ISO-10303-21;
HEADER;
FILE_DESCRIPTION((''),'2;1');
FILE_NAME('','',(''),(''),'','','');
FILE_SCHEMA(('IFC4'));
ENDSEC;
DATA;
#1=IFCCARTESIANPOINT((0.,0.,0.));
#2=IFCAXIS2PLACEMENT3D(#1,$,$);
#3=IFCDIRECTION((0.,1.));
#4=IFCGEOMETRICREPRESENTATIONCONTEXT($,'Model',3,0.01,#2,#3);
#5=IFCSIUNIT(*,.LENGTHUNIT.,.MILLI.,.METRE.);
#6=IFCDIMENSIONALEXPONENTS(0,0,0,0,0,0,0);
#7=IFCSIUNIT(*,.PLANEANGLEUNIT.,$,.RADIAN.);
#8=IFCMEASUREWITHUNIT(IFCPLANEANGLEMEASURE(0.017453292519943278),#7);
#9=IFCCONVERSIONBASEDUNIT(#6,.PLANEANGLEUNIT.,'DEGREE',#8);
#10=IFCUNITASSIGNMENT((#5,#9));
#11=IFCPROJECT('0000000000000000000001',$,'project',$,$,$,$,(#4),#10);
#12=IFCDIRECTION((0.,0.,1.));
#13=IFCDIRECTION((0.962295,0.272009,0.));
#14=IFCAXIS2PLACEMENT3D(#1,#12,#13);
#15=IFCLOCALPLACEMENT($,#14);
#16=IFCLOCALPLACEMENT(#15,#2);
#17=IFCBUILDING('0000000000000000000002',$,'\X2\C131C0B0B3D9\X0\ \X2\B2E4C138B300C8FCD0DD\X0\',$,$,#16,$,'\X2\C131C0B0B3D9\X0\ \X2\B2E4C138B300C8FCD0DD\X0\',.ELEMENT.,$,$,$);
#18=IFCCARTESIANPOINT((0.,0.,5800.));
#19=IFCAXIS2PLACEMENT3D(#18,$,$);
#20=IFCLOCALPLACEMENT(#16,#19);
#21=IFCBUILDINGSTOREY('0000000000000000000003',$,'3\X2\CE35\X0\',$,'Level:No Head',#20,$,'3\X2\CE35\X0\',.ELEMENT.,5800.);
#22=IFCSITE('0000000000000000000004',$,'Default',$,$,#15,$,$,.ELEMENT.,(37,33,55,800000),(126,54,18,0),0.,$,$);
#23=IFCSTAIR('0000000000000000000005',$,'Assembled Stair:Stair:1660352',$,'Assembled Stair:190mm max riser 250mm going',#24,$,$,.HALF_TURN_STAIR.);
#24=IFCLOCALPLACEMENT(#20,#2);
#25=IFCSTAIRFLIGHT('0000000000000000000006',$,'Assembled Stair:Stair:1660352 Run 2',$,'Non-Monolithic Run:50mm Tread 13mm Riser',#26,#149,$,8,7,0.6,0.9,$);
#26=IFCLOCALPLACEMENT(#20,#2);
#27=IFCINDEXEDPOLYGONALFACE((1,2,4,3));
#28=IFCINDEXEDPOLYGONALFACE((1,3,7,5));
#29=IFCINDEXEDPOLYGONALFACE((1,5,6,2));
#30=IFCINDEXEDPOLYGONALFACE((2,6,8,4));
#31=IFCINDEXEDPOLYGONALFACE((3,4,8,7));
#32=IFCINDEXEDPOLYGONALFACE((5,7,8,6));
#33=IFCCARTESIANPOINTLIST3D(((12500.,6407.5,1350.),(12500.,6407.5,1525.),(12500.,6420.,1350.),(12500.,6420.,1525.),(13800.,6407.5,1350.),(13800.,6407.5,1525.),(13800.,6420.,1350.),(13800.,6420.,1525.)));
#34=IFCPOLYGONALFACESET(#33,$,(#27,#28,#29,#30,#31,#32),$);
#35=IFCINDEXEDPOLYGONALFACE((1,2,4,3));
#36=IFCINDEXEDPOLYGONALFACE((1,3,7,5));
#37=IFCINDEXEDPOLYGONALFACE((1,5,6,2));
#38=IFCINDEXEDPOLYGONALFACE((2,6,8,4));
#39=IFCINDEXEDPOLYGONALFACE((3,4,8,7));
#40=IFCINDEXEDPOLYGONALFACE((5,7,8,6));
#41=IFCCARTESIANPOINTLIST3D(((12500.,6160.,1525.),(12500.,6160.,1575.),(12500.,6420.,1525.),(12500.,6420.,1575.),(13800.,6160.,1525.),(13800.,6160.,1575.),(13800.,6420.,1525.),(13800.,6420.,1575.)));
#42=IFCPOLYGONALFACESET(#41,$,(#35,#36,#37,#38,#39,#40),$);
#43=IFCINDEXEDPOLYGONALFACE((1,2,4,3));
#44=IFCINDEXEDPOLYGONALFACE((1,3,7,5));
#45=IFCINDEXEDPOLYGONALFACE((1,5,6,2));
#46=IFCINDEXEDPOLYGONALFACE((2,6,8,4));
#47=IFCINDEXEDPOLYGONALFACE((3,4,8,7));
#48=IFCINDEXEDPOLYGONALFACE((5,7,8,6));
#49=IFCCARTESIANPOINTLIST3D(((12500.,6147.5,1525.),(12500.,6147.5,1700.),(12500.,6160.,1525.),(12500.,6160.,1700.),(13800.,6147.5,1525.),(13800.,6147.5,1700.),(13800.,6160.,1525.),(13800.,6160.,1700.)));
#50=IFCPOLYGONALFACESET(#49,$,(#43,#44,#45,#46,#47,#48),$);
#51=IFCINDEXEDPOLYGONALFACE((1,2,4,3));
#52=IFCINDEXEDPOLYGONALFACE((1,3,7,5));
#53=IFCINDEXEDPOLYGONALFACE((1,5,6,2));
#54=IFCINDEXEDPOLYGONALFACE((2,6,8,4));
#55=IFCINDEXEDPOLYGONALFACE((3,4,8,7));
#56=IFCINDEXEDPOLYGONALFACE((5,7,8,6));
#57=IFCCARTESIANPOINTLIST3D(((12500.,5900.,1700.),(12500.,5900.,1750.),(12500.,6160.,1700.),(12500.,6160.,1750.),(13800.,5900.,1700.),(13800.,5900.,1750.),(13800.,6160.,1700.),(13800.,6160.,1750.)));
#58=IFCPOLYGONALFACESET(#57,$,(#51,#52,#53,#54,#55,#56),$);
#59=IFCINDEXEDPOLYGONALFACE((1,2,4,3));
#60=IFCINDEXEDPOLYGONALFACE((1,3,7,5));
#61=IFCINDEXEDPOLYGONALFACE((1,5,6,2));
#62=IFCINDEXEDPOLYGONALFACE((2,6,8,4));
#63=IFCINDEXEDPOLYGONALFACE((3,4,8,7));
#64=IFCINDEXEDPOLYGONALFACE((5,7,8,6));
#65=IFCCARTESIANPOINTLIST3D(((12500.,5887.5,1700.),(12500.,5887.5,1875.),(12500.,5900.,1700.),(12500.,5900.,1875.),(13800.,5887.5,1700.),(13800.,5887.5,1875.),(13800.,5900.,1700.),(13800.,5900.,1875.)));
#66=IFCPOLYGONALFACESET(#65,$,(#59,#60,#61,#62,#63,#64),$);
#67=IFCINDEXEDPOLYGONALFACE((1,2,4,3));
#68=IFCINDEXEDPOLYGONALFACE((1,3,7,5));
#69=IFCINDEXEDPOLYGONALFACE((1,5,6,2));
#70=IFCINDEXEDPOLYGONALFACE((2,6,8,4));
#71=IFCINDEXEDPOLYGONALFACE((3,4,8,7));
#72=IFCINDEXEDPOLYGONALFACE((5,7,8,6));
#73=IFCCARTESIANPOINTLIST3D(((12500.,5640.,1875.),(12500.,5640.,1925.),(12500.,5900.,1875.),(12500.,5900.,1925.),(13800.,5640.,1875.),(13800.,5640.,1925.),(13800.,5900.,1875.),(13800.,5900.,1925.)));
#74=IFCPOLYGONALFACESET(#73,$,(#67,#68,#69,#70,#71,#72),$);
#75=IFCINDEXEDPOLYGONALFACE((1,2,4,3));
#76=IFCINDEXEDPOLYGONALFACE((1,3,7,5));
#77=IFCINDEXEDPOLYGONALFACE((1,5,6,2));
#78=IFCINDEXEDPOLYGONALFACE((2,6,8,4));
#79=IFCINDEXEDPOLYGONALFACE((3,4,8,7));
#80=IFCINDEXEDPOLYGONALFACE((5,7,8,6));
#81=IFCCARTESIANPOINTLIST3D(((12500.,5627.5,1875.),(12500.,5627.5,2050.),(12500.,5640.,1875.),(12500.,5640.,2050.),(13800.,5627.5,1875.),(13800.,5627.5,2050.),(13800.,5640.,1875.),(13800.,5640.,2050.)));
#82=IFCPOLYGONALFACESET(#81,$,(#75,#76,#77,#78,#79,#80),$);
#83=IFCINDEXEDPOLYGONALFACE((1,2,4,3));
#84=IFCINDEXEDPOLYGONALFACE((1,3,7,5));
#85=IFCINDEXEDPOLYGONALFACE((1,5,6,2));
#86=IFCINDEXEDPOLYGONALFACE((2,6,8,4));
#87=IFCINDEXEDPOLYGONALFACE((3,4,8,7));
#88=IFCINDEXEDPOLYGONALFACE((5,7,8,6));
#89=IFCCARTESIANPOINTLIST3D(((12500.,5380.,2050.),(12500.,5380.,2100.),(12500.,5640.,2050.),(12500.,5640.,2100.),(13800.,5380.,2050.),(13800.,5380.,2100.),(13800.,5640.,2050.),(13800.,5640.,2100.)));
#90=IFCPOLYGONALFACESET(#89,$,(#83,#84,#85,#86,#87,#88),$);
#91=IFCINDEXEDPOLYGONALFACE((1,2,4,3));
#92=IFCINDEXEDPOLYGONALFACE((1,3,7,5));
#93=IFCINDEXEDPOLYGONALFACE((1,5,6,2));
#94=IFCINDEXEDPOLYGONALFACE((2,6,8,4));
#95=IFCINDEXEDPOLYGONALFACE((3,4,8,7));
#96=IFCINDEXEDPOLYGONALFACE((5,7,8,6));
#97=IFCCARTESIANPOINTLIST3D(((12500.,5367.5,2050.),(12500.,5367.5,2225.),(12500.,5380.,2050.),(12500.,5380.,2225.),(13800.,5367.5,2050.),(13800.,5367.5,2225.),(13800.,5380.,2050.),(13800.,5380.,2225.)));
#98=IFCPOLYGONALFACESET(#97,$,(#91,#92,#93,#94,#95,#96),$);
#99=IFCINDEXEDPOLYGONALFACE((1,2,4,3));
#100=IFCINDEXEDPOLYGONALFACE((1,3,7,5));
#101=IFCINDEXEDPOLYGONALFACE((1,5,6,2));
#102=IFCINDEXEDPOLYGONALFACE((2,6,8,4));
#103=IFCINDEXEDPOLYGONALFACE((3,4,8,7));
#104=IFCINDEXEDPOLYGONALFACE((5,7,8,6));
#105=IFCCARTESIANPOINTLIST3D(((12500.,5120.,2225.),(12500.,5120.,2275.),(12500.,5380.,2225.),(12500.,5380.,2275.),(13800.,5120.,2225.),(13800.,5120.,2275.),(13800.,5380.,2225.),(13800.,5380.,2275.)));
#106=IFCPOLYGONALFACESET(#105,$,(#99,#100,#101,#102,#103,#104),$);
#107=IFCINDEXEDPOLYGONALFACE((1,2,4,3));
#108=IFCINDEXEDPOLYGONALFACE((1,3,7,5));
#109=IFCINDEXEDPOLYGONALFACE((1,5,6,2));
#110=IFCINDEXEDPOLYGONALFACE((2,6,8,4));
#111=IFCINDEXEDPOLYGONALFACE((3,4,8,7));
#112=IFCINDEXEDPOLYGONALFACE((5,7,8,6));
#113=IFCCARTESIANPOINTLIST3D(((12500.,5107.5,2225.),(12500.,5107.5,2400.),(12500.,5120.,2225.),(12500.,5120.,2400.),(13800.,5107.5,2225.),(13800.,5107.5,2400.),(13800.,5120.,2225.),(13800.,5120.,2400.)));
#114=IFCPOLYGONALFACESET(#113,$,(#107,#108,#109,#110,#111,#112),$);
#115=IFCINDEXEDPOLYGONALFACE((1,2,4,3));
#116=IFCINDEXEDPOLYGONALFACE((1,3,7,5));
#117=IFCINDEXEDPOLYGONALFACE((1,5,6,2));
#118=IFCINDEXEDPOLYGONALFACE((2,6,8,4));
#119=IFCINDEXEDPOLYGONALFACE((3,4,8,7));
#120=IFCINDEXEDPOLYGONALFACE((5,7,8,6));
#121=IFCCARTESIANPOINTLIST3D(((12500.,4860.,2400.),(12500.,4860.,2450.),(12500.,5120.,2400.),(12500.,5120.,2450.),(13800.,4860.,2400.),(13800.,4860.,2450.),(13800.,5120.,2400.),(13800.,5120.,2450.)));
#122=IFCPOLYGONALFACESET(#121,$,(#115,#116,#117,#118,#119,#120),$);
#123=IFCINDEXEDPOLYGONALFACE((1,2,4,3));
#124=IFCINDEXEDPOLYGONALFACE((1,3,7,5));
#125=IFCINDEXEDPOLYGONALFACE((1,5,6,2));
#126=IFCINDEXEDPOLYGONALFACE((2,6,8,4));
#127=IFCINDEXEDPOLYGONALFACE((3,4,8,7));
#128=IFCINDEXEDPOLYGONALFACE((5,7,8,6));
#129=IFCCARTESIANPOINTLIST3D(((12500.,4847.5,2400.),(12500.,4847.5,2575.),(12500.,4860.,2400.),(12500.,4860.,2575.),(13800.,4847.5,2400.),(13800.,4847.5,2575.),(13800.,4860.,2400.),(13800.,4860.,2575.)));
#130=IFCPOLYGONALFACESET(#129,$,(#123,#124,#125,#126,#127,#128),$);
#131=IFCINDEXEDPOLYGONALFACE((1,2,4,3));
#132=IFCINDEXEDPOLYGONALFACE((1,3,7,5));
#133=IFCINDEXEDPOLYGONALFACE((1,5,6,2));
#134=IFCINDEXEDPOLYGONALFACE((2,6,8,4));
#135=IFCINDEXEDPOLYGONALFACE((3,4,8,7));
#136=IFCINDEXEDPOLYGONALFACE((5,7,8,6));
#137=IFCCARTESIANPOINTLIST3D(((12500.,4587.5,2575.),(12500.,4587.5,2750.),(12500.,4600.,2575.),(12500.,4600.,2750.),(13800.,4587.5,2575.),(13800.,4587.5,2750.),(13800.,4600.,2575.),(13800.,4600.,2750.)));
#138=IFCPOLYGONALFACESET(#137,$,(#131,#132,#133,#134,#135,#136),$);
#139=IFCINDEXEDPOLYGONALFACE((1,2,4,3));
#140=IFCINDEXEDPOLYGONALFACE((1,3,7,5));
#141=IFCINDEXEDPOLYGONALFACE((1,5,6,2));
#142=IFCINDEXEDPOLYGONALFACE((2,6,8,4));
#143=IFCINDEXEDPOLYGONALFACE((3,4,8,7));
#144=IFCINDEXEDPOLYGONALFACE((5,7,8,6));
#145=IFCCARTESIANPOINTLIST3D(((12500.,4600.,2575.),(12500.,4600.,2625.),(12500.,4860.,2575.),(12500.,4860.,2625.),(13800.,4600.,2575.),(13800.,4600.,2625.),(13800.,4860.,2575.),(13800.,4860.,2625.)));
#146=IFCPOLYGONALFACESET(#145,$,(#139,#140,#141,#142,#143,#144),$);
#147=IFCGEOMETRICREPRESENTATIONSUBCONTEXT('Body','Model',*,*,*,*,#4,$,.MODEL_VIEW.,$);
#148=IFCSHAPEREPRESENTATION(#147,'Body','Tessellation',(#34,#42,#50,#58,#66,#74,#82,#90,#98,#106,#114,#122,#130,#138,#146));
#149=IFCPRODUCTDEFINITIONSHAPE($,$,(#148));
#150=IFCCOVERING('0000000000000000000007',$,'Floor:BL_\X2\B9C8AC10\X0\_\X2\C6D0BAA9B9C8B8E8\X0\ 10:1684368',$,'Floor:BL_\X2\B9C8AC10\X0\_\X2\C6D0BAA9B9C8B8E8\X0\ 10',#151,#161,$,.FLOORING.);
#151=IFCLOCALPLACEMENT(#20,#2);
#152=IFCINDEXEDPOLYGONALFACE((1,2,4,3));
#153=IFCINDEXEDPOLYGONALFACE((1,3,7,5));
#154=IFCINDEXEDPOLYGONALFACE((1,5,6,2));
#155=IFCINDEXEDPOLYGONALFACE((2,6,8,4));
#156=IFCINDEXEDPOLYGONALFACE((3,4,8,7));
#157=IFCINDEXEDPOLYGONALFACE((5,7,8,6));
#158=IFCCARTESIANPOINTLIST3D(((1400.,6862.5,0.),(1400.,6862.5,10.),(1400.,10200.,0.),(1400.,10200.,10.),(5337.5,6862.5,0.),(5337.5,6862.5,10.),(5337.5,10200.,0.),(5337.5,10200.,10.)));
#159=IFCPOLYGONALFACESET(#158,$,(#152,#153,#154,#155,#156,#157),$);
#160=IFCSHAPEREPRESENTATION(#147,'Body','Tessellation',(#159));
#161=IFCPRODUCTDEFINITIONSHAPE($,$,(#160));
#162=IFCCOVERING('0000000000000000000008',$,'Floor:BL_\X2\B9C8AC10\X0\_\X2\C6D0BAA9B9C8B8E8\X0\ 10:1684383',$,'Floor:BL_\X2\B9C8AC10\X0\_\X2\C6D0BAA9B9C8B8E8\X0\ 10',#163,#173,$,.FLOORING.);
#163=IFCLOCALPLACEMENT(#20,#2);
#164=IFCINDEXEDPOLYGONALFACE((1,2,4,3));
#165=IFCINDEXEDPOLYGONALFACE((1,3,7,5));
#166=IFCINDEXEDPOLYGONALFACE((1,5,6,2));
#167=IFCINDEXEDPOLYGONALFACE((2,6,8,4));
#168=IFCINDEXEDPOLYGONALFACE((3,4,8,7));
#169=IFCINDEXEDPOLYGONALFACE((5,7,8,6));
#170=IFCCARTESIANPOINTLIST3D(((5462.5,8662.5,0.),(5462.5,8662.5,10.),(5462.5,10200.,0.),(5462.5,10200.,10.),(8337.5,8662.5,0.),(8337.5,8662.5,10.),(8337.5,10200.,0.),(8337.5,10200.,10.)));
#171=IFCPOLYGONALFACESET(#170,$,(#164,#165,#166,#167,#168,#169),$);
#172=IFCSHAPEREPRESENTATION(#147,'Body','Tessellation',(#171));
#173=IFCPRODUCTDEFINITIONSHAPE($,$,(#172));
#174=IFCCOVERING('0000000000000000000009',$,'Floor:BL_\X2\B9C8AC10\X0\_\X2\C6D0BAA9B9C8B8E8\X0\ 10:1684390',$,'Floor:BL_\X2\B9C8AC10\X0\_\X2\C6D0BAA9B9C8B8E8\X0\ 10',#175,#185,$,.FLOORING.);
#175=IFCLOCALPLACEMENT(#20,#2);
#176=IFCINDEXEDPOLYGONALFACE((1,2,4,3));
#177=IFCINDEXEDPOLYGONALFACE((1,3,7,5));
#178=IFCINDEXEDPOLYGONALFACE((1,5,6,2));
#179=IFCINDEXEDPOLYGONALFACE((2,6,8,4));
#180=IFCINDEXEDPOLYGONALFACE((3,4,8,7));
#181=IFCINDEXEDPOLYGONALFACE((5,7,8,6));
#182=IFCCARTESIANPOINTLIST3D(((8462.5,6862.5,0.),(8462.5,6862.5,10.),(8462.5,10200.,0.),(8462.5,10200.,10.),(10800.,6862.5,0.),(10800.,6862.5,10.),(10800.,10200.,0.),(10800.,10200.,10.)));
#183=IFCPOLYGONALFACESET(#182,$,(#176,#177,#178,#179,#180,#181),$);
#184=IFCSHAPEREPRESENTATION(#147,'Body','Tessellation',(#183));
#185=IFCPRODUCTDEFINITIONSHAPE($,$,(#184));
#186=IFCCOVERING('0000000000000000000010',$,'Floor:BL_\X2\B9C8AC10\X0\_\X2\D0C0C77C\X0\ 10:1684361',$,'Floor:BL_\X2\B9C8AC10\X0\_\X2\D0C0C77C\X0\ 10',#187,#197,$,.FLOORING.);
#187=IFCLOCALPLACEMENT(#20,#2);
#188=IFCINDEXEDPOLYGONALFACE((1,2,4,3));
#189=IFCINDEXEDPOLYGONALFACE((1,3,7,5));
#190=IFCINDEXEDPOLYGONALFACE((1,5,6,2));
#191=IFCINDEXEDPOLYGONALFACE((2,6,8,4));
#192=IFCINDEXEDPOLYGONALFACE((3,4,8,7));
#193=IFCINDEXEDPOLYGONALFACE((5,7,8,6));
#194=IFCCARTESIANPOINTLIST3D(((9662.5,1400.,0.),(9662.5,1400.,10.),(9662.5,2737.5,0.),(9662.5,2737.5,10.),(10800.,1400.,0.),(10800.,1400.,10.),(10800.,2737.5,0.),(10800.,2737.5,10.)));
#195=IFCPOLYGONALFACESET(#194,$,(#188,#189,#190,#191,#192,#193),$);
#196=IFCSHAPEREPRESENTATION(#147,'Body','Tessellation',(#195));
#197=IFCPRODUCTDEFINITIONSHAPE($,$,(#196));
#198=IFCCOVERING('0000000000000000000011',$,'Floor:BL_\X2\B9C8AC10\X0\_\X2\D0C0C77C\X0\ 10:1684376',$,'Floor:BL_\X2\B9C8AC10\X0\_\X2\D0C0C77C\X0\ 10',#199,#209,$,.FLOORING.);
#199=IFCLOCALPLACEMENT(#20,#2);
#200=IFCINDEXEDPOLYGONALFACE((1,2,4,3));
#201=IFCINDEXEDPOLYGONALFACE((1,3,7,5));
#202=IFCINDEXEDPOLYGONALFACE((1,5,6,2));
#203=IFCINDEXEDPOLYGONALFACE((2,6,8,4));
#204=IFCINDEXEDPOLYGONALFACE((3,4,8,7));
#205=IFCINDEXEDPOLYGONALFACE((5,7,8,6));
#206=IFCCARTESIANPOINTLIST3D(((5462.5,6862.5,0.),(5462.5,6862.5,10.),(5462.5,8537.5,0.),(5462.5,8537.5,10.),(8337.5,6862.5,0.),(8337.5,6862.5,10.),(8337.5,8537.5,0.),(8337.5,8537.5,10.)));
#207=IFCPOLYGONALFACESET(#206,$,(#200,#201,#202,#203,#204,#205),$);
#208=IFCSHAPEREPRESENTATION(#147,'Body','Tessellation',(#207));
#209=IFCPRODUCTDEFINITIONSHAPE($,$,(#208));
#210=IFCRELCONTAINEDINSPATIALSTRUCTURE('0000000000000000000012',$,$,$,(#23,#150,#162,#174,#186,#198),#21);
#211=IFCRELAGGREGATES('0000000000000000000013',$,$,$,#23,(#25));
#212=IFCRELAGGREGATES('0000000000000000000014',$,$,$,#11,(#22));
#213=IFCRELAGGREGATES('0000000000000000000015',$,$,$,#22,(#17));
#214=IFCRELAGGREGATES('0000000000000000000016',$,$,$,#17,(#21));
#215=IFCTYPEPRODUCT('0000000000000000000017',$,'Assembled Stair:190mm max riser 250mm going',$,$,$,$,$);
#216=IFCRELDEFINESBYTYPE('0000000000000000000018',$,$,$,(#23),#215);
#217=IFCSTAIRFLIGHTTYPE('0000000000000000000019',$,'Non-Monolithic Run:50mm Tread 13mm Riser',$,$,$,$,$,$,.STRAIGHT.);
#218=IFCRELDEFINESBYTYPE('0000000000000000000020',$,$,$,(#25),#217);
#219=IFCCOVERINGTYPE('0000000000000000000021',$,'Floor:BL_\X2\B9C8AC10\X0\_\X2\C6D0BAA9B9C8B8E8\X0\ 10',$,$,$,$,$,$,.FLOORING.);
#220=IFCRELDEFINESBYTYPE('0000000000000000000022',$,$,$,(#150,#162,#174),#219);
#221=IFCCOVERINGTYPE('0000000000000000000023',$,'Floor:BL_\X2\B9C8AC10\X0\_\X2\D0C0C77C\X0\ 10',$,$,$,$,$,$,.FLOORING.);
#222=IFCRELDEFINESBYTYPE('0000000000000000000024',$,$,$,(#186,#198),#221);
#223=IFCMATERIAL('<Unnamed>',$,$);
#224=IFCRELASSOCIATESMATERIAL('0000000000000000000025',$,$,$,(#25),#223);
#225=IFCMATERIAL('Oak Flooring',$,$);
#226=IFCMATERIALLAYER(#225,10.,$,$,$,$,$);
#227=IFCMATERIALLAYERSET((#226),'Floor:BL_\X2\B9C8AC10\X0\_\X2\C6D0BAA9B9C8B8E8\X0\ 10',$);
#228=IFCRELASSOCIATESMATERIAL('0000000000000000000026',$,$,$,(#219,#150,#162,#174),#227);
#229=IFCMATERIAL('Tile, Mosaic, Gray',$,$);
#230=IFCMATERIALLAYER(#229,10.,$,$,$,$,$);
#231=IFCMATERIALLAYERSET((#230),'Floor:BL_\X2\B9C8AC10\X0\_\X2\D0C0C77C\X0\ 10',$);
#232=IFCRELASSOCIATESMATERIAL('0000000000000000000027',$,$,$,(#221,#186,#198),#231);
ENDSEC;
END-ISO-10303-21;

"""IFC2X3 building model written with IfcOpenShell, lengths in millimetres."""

from ifc_helpers import new_model, entity, si_unit, converted_unit, direction, frame, frame_2d, origin, origin_2d_with_axis, place, context, subcontext, project, spatial, rectangle, extrude, material, layer, layer_set, layer_usage, type_object, element, aggregate, save


model = new_model("IFC2X3")

# Units and contexts
model_context = context("Model", 3, precision=0.01, world=origin(), true_north=direction((0.0, 1.0)))
body_context = subcontext(model_context, "Body", "Model", "MODEL_VIEW")
ifc_project = project(units=[si_unit("LENGTHUNIT", "METRE", prefix="MILLI"), converted_unit("PLANEANGLEUNIT", "DEGREE", entity("IfcPlaneAngleMeasure", 0.017453292519943278), si_unit("PLANEANGLEUNIT", "RADIAN"), dimensions=[0, 0, 0, 0, 0, 0, 0])], contexts=[model_context])

# Site, building, storey
site_placement = place(None, frame((0.0, 0.0, 0.0), z_axis=(0.0, 0.0, 1.0), x_axis=(0.962295, 0.272009, 0.0)))
site = spatial("IfcSite", under=ifc_project, at=site_placement, Name="Default", CompositionType="ELEMENT", RefLatitude=(37, 33, 55, 800000), RefLongitude=(126, 54, 18, 0), RefElevation=0.0)
building_placement = place(site_placement, origin())
building = spatial("IfcBuilding", under=site, at=building_placement, Name="성산동 다세대주택", LongName="성산동 다세대주택", CompositionType="ELEMENT")
storey_placement = place(building_placement, frame((0.0, 0.0, 5800.0)))
storey = spatial("IfcBuildingStorey", under=building, at=storey_placement, Name="3층", ObjectType="Level:No Head", LongName="3층", CompositionType="ELEMENT", Elevation=5800.0)

# Stair
type_product = type_object("IfcTypeProduct", Name="Assembled Stair:190mm max riser 250mm going")
stair_placement = place(storey_placement, origin())
stair = element("IfcStair", 1, at=stair_placement, inside=storey, type_object=type_product, Name="Assembled Stair:Stair:1660352", ObjectType="Assembled Stair:190mm max riser 250mm going", ShapeType="HALF_TURN_STAIR")
ifc_material_1 = material(Name="<Unnamed>")

# Stair flight
stair_flight_type = type_object("IfcStairFlightType", Name="Non-Monolithic Run:50mm Tread 13mm Riser", PredefinedType="STRAIGHT")
stair_flight_1_placement = place(stair_placement, origin())
stair_flight_1 = element("IfcStairFlight", 2, at=stair_flight_1_placement, type_object=stair_flight_type, material=ifc_material_1, Name="Assembled Stair:Stair:1660352 Run 2", ObjectType="Non-Monolithic Run:50mm Tread 13mm Riser", NumberOfRiser=8, NumberOfTreads=7, RiserHeight=0.6, TreadLength=0.9, context=body_context, shape_type="SweptSolid", body=[
    extrude(rectangle(XDim=1300.0, YDim=12.5, at=frame_2d((0.0, 0.0), x_axis=(1.0, 0.0))), frame((13150.0, 6413.7, 1350.0)), (0.0, 0.0, 1.0), 175.0),
    extrude(rectangle(XDim=260.0, YDim=1300.0, at=frame_2d((0.0, 0.0), x_axis=(1.0, 0.0))), frame((13150.0, 6290.0, 1525.0), z_axis=(0.0, 0.0, 1.0), x_axis=(0.0, 1.0, 0.0)), (0.0, 0.0, 1.0), 50.0),
    extrude(rectangle(XDim=1300.0, YDim=12.5, at=frame_2d((0.0, 0.0), x_axis=(1.0, 0.0))), frame((13150.0, 6153.7, 1525.0)), (0.0, 0.0, 1.0), 175.0),
    extrude(rectangle(XDim=260.0, YDim=1300.0, at=origin_2d_with_axis()), frame((13150.0, 6030.0, 1700.0), z_axis=(0.0, 0.0, 1.0), x_axis=(0.0, 1.0, 0.0)), (0.0, 0.0, 1.0), 50.0),
    extrude(rectangle(XDim=1300.0, YDim=12.5, at=frame_2d((0.0, 0.0), x_axis=(1.0, 0.0))), frame((13150.0, 5893.7, 1700.0)), (0.0, 0.0, 1.0), 175.0),
    extrude(rectangle(XDim=260.0, YDim=1300.0, at=origin_2d_with_axis()), frame((13150.0, 5770.0, 1875.0), z_axis=(0.0, 0.0, 1.0), x_axis=(0.0, 1.0, 0.0)), (0.0, 0.0, 1.0), 50.0),
    extrude(rectangle(XDim=1300.0, YDim=12.5, at=frame_2d((0.0, 0.0), x_axis=(1.0, 0.0))), frame((13150.0, 5633.7, 1875.0)), (0.0, 0.0, 1.0), 175.0),
    extrude(rectangle(XDim=260.0, YDim=1300.0, at=origin_2d_with_axis()), frame((13150.0, 5510.0, 2050.0), z_axis=(0.0, 0.0, 1.0), x_axis=(0.0, 1.0, 0.0)), (0.0, 0.0, 1.0), 50.0),
    extrude(rectangle(XDim=1300.0, YDim=12.5, at=frame_2d((0.0, 0.0), x_axis=(1.0, 0.0))), frame((13150.0, 5373.7, 2050.0)), (0.0, 0.0, 1.0), 175.0),
    extrude(rectangle(XDim=260.0, YDim=1300.0, at=origin_2d_with_axis()), frame((13150.0, 5250.0, 2225.0), z_axis=(0.0, 0.0, 1.0), x_axis=(0.0, 1.0, 0.0)), (0.0, 0.0, 1.0), 50.0),
    extrude(rectangle(XDim=1300.0, YDim=12.5, at=frame_2d((0.0, 0.0), x_axis=(1.0, 0.0))), frame((13150.0, 5113.7, 2225.0)), (0.0, 0.0, 1.0), 175.0),
    extrude(rectangle(XDim=260.0, YDim=1300.0, at=origin_2d_with_axis()), frame((13150.0, 4990.0, 2400.0), z_axis=(0.0, 0.0, 1.0), x_axis=(0.0, 1.0, 0.0)), (0.0, 0.0, 1.0), 50.0),
    extrude(rectangle(XDim=1300.0, YDim=12.5, at=frame_2d((0.0, 0.0), x_axis=(1.0, 0.0))), frame((13150.0, 4853.7, 2400.0)), (0.0, 0.0, 1.0), 175.0),
    extrude(rectangle(XDim=1300.0, YDim=12.5, at=frame_2d((0.0, 0.0), x_axis=(1.0, 0.0))), frame((13150.0, 4593.8, 2575.0)), (0.0, 0.0, 1.0), 175.0),
    extrude(rectangle(XDim=260.0, YDim=1300.0, at=origin_2d_with_axis()), frame((13150.0, 4730.0, 2575.0), z_axis=(0.0, 0.0, 1.0), x_axis=(0.0, 1.0, 0.0)), (0.0, 0.0, 1.0), 50.0),
])
aggregate(stair, [stair_flight_1])

# Coverings
ifc_material_2 = material(Name="Oak Flooring")
ifc_layer_1 = layer(ifc_material_2, 10.0)
ifc_layer_set_1 = layer_set([ifc_layer_1], Name="Floor:BL_마감_원목마루 10")
covering_type_1 = type_object("IfcCoveringType", Name="Floor:BL_마감_원목마루 10", PredefinedType="FLOORING", material=ifc_layer_set_1)
ifc_layer_usage_1 = layer_usage(ifc_layer_set_1, "AXIS3", "POSITIVE", 0.0)
covering_1_placement = place(storey_placement, origin())
element("IfcCovering", 3, at=covering_1_placement, inside=storey, type_object=covering_type_1, material=ifc_layer_usage_1, Name="Floor:BL_마감_원목마루 10:1684368", ObjectType="Floor:BL_마감_원목마루 10", PredefinedType="FLOORING", context=body_context, shape_type="SweptSolid", body=[
    extrude(rectangle(XDim=3337.5, YDim=3937.5, at=frame_2d((0.0, 0.0), x_axis=(1.0, 0.0))), frame((3368.8, 8531.3, 10.0), z_axis=(0.0, 0.0, -1.0), x_axis=(0.0, 1.0, 0.0)), (0.0, 0.0, 1.0), 10.0),
])
ifc_layer_usage_2 = layer_usage(ifc_layer_set_1, "AXIS3", "POSITIVE", 0.0)
covering_2_placement = place(storey_placement, origin())
element("IfcCovering", 4, at=covering_2_placement, inside=storey, type_object=covering_type_1, material=ifc_layer_usage_2, Name="Floor:BL_마감_원목마루 10:1684383", ObjectType="Floor:BL_마감_원목마루 10", PredefinedType="FLOORING", context=body_context, shape_type="SweptSolid", body=[
    extrude(rectangle(XDim=1537.5, YDim=2875.0, at=frame_2d((0.0, 0.0), x_axis=(1.0, 0.0))), frame((6900.0, 9431.2, 10.0), z_axis=(0.0, 0.0, -1.0), x_axis=(0.0, 1.0, 0.0)), (0.0, 0.0, 1.0), 10.0),
])
ifc_layer_usage_3 = layer_usage(ifc_layer_set_1, "AXIS3", "POSITIVE", 0.0)
covering_3_placement = place(storey_placement, origin())
element("IfcCovering", 5, at=covering_3_placement, inside=storey, type_object=covering_type_1, material=ifc_layer_usage_3, Name="Floor:BL_마감_원목마루 10:1684390", ObjectType="Floor:BL_마감_원목마루 10", PredefinedType="FLOORING", context=body_context, shape_type="SweptSolid", body=[
    extrude(rectangle(XDim=2337.5, YDim=3337.5, at=frame_2d((0.0, 0.0), x_axis=(1.0, 0.0))), frame((9631.2, 8531.2, 10.0), z_axis=(0.0, 0.0, -1.0), x_axis=(1.0, 0.0, 0.0)), (0.0, 0.0, 1.0), 10.0),
])
ifc_material_3 = material(Name="Tile, Mosaic, Gray")
ifc_layer_2 = layer(ifc_material_3, 10.0)
ifc_layer_set_2 = layer_set([ifc_layer_2], Name="Floor:BL_마감_타일 10")
ifc_layer_usage_4 = layer_usage(ifc_layer_set_2, "AXIS3", "POSITIVE", 0.0)
covering_type_2 = type_object("IfcCoveringType", Name="Floor:BL_마감_타일 10", PredefinedType="FLOORING", material=ifc_layer_set_2)
covering_4_placement = place(storey_placement, origin())
element("IfcCovering", 6, at=covering_4_placement, inside=storey, type_object=covering_type_2, material=ifc_layer_usage_4, Name="Floor:BL_마감_타일 10:1684361", ObjectType="Floor:BL_마감_타일 10", PredefinedType="FLOORING", context=body_context, shape_type="SweptSolid", body=[
    extrude(rectangle(XDim=1337.5, YDim=1137.5, at=frame_2d((0.0, 0.0), x_axis=(1.0, 0.0))), frame((10231.2, 2068.8, 10.0), z_axis=(0.0, 0.0, -1.0), x_axis=(0.0, 1.0, 0.0)), (0.0, 0.0, 1.0), 10.0),
])
ifc_layer_usage_5 = layer_usage(ifc_layer_set_2, "AXIS3", "POSITIVE", 0.0)
covering_5_placement = place(storey_placement, origin())
element("IfcCovering", 7, at=covering_5_placement, inside=storey, type_object=covering_type_2, material=ifc_layer_usage_5, Name="Floor:BL_마감_타일 10:1684376", ObjectType="Floor:BL_마감_타일 10", PredefinedType="FLOORING", context=body_context, shape_type="SweptSolid", body=[
    extrude(rectangle(XDim=1675.0, YDim=2875.0, at=frame_2d((0.0, 0.0), x_axis=(1.0, 0.0))), frame((6900.0, 7700.0, 10.0), z_axis=(0.0, 0.0, -1.0), x_axis=(0.0, 1.0, 0.0)), (0.0, 0.0, 1.0), 10.0),
])

save(model, "model.ifc")
